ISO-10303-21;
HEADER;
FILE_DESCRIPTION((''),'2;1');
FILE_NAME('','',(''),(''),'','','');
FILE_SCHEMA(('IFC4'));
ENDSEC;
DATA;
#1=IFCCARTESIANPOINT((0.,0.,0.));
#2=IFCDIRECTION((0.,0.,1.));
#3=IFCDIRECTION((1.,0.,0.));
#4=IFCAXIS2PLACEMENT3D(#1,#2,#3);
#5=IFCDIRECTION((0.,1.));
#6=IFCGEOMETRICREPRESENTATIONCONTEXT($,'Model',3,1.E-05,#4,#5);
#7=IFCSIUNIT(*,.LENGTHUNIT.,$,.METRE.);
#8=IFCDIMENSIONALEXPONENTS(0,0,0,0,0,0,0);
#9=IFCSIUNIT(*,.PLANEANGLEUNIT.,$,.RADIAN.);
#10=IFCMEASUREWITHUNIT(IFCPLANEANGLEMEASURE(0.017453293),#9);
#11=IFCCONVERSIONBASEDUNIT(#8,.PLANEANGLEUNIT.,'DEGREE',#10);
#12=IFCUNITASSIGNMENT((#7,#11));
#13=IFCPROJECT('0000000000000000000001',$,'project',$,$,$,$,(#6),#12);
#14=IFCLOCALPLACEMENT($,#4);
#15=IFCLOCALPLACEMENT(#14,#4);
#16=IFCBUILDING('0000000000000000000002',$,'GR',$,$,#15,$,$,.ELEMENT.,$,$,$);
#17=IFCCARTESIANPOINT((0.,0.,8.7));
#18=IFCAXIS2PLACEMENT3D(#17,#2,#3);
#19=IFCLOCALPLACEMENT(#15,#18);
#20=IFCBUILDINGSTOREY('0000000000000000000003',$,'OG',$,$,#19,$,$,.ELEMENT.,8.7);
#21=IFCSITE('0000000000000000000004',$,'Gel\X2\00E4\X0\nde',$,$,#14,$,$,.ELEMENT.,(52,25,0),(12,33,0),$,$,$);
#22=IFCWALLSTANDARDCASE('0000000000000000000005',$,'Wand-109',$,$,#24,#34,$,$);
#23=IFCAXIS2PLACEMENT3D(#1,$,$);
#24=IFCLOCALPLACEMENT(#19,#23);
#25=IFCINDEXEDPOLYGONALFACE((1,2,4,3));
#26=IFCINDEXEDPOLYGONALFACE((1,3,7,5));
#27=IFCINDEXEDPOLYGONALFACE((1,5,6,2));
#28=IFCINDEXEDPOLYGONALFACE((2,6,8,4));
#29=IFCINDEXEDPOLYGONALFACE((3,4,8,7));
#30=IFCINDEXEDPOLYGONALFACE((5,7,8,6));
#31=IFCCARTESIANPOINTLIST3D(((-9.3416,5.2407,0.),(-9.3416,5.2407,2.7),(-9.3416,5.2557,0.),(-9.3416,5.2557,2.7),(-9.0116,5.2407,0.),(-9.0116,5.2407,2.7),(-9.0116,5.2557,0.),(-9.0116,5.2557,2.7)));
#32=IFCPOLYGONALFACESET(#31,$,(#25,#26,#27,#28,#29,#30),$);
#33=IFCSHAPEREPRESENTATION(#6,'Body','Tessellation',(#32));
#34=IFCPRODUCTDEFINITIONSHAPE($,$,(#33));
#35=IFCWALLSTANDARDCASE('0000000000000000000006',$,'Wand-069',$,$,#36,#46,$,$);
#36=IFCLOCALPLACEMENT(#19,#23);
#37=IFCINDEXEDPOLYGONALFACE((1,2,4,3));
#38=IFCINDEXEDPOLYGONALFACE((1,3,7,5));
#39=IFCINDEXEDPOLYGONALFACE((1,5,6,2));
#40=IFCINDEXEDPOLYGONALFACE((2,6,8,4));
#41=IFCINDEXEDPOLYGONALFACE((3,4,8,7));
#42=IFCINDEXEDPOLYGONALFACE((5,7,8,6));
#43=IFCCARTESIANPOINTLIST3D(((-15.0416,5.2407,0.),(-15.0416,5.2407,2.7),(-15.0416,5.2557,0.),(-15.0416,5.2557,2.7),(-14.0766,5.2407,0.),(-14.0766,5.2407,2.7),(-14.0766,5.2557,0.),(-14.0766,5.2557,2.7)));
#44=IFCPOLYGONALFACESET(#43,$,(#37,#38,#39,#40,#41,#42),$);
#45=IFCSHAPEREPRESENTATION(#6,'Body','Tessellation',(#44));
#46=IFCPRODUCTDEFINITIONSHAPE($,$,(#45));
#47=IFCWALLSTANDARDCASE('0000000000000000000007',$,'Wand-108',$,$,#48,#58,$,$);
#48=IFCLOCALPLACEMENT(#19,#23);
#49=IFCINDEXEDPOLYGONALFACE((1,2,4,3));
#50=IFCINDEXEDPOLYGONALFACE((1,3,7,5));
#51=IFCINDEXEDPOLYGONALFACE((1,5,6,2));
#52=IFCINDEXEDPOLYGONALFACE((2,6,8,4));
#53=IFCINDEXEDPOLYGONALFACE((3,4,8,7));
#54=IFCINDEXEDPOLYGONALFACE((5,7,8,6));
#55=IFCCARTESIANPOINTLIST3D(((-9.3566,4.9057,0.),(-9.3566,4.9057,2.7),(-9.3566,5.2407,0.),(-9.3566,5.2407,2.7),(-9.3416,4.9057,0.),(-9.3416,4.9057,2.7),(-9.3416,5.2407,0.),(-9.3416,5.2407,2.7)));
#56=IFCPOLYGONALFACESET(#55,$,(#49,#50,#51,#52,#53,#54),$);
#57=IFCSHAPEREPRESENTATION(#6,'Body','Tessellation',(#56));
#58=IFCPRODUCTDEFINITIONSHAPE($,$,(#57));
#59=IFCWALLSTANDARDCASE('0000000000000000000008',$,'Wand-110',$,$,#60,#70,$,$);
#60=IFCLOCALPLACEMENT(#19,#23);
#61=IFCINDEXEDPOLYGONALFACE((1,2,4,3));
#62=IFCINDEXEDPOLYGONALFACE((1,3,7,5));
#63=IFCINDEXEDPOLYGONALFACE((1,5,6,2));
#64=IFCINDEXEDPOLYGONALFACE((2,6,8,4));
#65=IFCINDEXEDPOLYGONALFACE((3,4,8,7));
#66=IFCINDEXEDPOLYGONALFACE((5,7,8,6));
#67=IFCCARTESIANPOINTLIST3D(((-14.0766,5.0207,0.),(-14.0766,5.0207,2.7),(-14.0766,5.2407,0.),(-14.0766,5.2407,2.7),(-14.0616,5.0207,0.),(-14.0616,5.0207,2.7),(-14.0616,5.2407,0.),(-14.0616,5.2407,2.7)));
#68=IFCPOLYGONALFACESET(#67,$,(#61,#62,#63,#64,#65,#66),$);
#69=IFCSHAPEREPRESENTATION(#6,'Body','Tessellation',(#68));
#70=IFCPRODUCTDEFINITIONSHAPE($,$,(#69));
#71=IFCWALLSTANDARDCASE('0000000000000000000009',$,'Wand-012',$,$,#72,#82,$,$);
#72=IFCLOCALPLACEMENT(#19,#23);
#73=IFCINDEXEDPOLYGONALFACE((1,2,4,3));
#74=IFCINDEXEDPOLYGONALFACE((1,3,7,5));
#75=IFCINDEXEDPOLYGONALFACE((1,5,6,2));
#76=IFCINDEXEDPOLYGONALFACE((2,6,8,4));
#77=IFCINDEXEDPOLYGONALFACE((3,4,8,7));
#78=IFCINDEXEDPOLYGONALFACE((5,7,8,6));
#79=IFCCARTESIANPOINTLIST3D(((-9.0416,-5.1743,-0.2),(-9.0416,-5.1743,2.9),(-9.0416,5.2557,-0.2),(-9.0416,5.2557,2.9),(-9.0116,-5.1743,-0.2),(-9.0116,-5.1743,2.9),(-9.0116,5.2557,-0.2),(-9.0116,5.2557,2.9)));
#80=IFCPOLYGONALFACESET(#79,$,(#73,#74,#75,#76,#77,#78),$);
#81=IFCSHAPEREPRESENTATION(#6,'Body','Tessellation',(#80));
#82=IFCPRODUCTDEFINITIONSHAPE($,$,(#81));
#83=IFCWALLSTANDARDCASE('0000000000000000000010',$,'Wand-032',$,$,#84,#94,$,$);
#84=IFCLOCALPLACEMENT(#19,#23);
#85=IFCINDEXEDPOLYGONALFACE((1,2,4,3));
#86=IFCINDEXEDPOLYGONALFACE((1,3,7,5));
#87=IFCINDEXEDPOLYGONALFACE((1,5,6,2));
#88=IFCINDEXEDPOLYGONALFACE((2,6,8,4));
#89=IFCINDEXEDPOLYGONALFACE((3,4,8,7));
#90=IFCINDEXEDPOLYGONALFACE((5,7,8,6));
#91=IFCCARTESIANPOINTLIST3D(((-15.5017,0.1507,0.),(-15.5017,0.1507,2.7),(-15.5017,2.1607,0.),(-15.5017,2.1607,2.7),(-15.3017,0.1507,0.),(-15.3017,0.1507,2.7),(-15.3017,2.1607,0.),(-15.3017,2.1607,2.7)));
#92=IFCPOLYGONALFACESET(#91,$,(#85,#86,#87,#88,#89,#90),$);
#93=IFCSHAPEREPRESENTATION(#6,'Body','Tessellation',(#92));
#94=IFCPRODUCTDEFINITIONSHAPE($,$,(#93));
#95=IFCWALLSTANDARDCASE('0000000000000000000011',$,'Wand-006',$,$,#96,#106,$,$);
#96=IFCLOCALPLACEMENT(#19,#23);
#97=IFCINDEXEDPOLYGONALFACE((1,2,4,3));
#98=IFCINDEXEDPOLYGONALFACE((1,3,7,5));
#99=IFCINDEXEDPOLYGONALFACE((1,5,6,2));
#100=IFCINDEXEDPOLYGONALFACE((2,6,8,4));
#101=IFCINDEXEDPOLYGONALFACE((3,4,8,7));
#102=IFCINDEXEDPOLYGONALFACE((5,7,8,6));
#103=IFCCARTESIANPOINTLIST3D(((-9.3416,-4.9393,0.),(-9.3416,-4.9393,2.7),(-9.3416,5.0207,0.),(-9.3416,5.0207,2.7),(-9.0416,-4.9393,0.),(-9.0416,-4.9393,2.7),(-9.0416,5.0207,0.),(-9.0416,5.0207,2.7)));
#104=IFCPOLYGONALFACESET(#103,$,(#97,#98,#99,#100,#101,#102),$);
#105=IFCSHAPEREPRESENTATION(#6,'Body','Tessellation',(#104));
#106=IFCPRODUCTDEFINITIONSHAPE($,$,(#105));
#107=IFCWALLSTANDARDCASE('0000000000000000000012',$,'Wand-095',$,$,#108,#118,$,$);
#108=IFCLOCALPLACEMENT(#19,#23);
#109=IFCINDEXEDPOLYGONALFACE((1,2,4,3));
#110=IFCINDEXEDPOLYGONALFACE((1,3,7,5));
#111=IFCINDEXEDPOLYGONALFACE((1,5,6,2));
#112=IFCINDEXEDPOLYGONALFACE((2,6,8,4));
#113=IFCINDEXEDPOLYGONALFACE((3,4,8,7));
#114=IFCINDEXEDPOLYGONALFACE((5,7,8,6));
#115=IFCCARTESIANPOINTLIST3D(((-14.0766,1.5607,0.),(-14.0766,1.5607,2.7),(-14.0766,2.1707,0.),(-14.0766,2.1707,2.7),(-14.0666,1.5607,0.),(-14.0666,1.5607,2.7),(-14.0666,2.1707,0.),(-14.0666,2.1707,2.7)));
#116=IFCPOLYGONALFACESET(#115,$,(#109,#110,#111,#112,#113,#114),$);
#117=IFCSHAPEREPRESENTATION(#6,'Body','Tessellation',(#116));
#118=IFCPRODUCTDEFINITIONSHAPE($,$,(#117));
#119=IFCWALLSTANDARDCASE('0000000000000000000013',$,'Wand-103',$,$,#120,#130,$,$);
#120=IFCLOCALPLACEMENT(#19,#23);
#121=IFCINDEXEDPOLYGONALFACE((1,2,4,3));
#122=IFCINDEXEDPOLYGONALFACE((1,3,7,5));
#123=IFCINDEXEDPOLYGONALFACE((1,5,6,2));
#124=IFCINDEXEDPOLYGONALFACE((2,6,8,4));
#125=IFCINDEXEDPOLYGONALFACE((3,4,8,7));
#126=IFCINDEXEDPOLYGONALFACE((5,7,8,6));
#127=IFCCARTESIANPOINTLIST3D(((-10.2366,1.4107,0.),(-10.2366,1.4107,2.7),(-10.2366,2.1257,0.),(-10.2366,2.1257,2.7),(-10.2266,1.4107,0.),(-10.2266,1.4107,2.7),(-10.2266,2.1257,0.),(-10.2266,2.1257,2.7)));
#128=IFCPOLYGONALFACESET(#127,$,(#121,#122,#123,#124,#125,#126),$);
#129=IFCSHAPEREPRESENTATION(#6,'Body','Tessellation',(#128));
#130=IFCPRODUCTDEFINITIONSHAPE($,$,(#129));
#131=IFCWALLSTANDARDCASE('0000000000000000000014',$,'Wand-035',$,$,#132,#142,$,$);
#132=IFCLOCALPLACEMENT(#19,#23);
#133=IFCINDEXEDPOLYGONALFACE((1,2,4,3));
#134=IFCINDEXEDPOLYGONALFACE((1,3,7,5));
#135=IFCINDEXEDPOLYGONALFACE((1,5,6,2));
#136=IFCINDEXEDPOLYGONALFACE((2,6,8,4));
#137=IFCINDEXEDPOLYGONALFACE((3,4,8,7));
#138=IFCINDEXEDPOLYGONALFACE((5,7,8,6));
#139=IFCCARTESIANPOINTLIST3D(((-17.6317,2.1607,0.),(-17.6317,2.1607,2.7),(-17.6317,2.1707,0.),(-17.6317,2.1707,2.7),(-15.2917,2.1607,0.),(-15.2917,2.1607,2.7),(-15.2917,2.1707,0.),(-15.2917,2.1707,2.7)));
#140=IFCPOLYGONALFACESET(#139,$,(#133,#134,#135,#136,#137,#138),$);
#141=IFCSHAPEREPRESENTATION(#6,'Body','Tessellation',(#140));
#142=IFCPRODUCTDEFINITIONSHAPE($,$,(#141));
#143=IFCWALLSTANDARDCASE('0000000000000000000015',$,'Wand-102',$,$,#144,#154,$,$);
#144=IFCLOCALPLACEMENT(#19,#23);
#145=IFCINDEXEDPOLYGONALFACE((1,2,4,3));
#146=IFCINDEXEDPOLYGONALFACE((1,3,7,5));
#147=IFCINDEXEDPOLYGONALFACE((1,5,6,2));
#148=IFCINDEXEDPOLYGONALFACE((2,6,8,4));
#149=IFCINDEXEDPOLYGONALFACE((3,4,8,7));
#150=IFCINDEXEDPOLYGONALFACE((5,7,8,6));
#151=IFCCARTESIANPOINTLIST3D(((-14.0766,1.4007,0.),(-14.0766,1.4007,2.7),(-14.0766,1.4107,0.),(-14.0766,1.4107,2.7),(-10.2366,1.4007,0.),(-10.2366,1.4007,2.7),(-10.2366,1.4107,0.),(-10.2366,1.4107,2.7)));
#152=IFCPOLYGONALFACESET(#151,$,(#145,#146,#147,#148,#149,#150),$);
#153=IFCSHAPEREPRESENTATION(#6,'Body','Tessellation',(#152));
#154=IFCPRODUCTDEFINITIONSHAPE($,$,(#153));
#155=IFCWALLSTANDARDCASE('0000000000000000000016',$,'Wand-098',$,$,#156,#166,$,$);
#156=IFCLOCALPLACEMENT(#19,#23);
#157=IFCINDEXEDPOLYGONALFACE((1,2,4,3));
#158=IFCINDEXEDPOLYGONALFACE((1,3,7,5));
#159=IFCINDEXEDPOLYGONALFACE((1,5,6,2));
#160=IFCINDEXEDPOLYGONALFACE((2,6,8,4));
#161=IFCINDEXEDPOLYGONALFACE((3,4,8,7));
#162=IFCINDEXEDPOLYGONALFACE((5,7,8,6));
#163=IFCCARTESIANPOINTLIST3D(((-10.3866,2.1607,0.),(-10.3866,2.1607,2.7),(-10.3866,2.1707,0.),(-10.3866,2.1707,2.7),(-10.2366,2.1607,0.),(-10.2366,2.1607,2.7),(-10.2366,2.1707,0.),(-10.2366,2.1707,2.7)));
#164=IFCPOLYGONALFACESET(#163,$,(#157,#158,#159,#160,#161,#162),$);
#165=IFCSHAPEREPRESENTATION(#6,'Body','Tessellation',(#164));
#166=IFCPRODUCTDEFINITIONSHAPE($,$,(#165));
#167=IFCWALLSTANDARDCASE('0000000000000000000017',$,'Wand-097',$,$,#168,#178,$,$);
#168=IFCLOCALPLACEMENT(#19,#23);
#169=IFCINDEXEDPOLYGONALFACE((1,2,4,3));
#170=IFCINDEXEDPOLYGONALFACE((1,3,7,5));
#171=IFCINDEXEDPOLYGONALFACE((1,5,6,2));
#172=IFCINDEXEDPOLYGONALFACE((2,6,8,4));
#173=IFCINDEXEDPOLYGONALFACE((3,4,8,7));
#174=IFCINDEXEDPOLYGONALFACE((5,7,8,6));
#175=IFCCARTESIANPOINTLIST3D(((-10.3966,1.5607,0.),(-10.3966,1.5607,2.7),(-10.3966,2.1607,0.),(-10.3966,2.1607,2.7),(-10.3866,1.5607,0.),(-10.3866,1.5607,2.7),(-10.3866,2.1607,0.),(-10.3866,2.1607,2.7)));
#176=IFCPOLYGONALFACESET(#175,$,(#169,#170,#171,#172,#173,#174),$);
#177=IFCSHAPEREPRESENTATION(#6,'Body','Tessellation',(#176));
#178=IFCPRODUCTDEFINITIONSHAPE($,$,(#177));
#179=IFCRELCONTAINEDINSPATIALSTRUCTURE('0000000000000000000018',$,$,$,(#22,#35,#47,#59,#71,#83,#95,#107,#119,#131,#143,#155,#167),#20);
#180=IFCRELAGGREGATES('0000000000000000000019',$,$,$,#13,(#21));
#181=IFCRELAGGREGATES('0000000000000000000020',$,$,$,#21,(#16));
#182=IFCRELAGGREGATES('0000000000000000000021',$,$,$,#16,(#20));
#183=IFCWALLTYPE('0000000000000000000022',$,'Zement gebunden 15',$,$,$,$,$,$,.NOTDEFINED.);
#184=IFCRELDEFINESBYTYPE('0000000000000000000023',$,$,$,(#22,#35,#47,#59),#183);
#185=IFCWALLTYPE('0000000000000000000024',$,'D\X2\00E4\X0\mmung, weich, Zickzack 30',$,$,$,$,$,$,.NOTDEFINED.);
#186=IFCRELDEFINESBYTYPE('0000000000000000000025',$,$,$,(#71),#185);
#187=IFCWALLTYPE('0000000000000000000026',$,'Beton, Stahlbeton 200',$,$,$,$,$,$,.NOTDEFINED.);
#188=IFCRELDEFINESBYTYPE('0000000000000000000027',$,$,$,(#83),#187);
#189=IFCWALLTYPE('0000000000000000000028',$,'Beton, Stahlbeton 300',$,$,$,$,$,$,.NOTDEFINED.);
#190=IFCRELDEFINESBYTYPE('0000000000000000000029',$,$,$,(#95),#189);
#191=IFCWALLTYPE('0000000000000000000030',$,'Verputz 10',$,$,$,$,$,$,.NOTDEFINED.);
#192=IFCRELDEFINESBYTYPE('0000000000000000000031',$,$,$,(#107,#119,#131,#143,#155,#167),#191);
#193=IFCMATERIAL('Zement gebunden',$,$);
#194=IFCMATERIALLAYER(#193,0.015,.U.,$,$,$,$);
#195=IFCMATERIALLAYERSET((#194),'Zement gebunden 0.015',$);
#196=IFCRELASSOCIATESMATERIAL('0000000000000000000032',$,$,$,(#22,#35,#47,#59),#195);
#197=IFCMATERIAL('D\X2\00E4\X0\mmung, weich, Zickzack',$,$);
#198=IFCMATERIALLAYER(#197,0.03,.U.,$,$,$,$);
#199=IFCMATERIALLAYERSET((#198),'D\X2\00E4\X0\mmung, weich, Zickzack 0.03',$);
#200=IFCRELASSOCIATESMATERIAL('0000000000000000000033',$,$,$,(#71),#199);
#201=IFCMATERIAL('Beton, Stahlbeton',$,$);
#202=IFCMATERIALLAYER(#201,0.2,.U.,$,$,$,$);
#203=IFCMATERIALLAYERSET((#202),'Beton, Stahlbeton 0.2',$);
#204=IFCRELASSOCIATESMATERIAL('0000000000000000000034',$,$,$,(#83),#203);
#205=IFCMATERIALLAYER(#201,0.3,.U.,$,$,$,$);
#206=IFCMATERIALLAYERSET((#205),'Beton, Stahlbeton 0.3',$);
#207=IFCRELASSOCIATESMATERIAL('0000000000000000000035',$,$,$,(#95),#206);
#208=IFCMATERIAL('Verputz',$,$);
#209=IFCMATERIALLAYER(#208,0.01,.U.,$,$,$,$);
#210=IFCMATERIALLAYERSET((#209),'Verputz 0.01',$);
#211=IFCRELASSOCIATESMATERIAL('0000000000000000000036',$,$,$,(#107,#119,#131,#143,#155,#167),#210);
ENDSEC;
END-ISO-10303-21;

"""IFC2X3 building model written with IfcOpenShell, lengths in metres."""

from ifc_helpers import new_model, entity, si_unit, converted_unit, direction, frame, origin_with_axes, place, context, project, spatial, polyline, outline, extrude, material, layer, layer_set, layer_usage, type_object, element, save


model = new_model("IFC2X3")

# Units and contexts
model_context = context("Model", 3, precision=1e-05, world=origin_with_axes(), true_north=direction((0.0, 1.0)))
ifc_project = project(units=[si_unit("LENGTHUNIT", "METRE"), converted_unit("PLANEANGLEUNIT", "DEGREE", entity("IfcPlaneAngleMeasure", 0.017453293), si_unit("PLANEANGLEUNIT", "RADIAN"), dimensions=[0, 0, 0, 0, 0, 0, 0])], contexts=[model_context])

# Site, building, storey
site_placement = place(None, origin_with_axes())
site = spatial("IfcSite", under=ifc_project, at=site_placement, Name="Gelände", CompositionType="ELEMENT", RefLatitude=(52, 25, 0), RefLongitude=(12, 33, 0))
building_placement = place(site_placement, origin_with_axes())
building = spatial("IfcBuilding", under=site, at=building_placement, Name="GR", CompositionType="ELEMENT")
storey_placement = place(building_placement, frame((0.0, 0.0, 8.7), z_axis=(0.0, 0.0, 1.0), x_axis=(1.0, 0.0, 0.0)))
storey = spatial("IfcBuildingStorey", under=building, at=storey_placement, Name="OG", CompositionType="ELEMENT", Elevation=8.7)

# Walls
ifc_material_1 = material(Name="Zement gebunden")
ifc_layer_1 = layer(ifc_material_1, 0.015, ventilated="UNKNOWN")
ifc_layer_set_1 = layer_set([ifc_layer_1], Name="Zement gebunden 0.015")
ifc_layer_usage_1 = layer_usage(ifc_layer_set_1, "AXIS2", "POSITIVE", 0.0)
wall_type_1 = type_object("IfcWallType", Name="Zement gebunden 15", PredefinedType="NOTDEFINED")
wall_1_placement = place(storey_placement, frame((-9.3416, 5.2407, 0.0), z_axis=(0.0, 0.0, 1.0), x_axis=(1.0, 0.0, 0.0)))
element("IfcWallStandardCase", 1, at=wall_1_placement, inside=storey, type_object=wall_type_1, material=ifc_layer_usage_1, Name="Wand-109", context=model_context, shape_type="SweptSolid", body=[
    extrude(outline(polyline([(0.0, 0.0), (0.33, 0.0), (0.33, 0.015), (0.0, 0.015), (0.0, 0.0)])), origin_with_axes(), (0.0, 0.0, 1.0), 2.7),
])
ifc_layer_usage_2 = layer_usage(ifc_layer_set_1, "AXIS2", "NEGATIVE", 0.0)
wall_2_placement = place(storey_placement, frame((-14.0766, 5.2407, 0.0), z_axis=(0.0, 0.0, 1.0), x_axis=(-1.0, 0.0, 0.0)))
element("IfcWallStandardCase", 2, at=wall_2_placement, inside=storey, type_object=wall_type_1, material=ifc_layer_usage_2, Name="Wand-069", context=model_context, shape_type="SweptSolid", body=[
    extrude(outline(polyline([(0.0, -0.015), (0.965, -0.015), (0.965, 0.0), (0.0, 0.0), (0.0, -0.015)])), origin_with_axes(), (0.0, 0.0, 1.0), 2.7),
])
ifc_layer_usage_3 = layer_usage(ifc_layer_set_1, "AXIS2", "POSITIVE", 0.0)
wall_3_placement = place(storey_placement, frame((-9.3416, 4.9057, 0.0), z_axis=(0.0, 0.0, 1.0), x_axis=(0.0, 1.0, 0.0)))
element("IfcWallStandardCase", 3, at=wall_3_placement, inside=storey, type_object=wall_type_1, material=ifc_layer_usage_3, Name="Wand-108", context=model_context, shape_type="SweptSolid", body=[
    extrude(outline(polyline([(0.0, 0.0), (0.335, 0.0), (0.335, 0.015), (0.0, 0.015), (0.0, 0.0)])), origin_with_axes(), (0.0, 0.0, 1.0), 2.7),
])
ifc_layer_usage_4 = layer_usage(ifc_layer_set_1, "AXIS2", "NEGATIVE", 0.0)
wall_4_placement = place(storey_placement, frame((-14.0766, 5.0207, 0.0), z_axis=(0.0, 0.0, 1.0), x_axis=(0.0, 1.0, 0.0)))
element("IfcWallStandardCase", 4, at=wall_4_placement, inside=storey, type_object=wall_type_1, material=ifc_layer_usage_4, Name="Wand-110", context=model_context, shape_type="SweptSolid", body=[
    extrude(outline(polyline([(0.0, -0.015), (0.22, -0.015), (0.22, 0.0), (0.0, 0.0), (0.0, -0.015)])), origin_with_axes(), (0.0, 0.0, 1.0), 2.7),
])
ifc_material_2 = material(Name="Dämmung, weich, Zickzack")
ifc_layer_2 = layer(ifc_material_2, 0.03, ventilated="UNKNOWN")
ifc_layer_set_2 = layer_set([ifc_layer_2], Name="Dämmung, weich, Zickzack 0.03")
ifc_layer_usage_5 = layer_usage(ifc_layer_set_2, "AXIS2", "POSITIVE", 0.0)
wall_type_2 = type_object("IfcWallType", Name="Dämmung, weich, Zickzack 30", PredefinedType="NOTDEFINED")
wall_5_placement = place(storey_placement, frame((-9.0416, 5.2557, -0.2), z_axis=(0.0, 0.0, 1.0), x_axis=(0.0, -1.0, 0.0)))
element("IfcWallStandardCase", 5, at=wall_5_placement, inside=storey, type_object=wall_type_2, material=ifc_layer_usage_5, Name="Wand-012", context=model_context, shape_type="SweptSolid", body=[
    extrude(outline(polyline([(0.0, 0.0), (10.43, 0.0), (10.43, 0.03), (0.0, 0.03), (0.0, 0.0)])), origin_with_axes(), (0.0, 0.0, 1.0), 3.1),
])
ifc_material_3 = material(Name="Beton, Stahlbeton")
ifc_layer_3 = layer(ifc_material_3, 0.2, ventilated="UNKNOWN")
ifc_layer_set_3 = layer_set([ifc_layer_3], Name="Beton, Stahlbeton 0.2")
ifc_layer_usage_6 = layer_usage(ifc_layer_set_3, "AXIS2", "NEGATIVE", 0.0)
wall_type_3 = type_object("IfcWallType", Name="Beton, Stahlbeton 200", PredefinedType="NOTDEFINED")
wall_6_placement = place(storey_placement, frame((-15.3017, 2.1607, 0.0), z_axis=(0.0, 0.0, 1.0), x_axis=(0.0, -1.0, 0.0)))
element("IfcWallStandardCase", 6, at=wall_6_placement, inside=storey, type_object=wall_type_3, material=ifc_layer_usage_6, Name="Wand-032", context=model_context, shape_type="SweptSolid", body=[
    extrude(outline(polyline([(0.0, -0.2), (2.01, -0.2), (2.01, 0.0), (0.0, 0.0), (0.0, -0.2)])), origin_with_axes(), (0.0, 0.0, 1.0), 2.7),
])
ifc_layer_4 = layer(ifc_material_3, 0.3, ventilated="UNKNOWN")
ifc_layer_set_4 = layer_set([ifc_layer_4], Name="Beton, Stahlbeton 0.3")
ifc_layer_usage_7 = layer_usage(ifc_layer_set_4, "AXIS2", "NEGATIVE", 0.0)
wall_type_4 = type_object("IfcWallType", Name="Beton, Stahlbeton 300", PredefinedType="NOTDEFINED")
wall_7_placement = place(storey_placement, frame((-9.0416, 5.0207, 0.0), z_axis=(0.0, 0.0, 1.0), x_axis=(0.0, -1.0, 0.0)))
element("IfcWallStandardCase", 7, at=wall_7_placement, inside=storey, type_object=wall_type_4, material=ifc_layer_usage_7, Name="Wand-006", context=model_context, shape_type="SweptSolid", body=[
    extrude(outline(polyline([(0.0, -0.3), (9.96, -0.3), (9.96, 0.0), (0.0, 0.0), (0.0, -0.3)])), origin_with_axes(), (0.0, 0.0, 1.0), 2.7),
])
ifc_material_4 = material(Name="Verputz")
ifc_layer_5 = layer(ifc_material_4, 0.01, ventilated="UNKNOWN")
ifc_layer_set_5 = layer_set([ifc_layer_5], Name="Verputz 0.01")
ifc_layer_usage_8 = layer_usage(ifc_layer_set_5, "AXIS2", "POSITIVE", 0.0)
wall_type_5 = type_object("IfcWallType", Name="Verputz 10", PredefinedType="NOTDEFINED")
wall_8_placement = place(storey_placement, frame((-14.0766, 2.1707, 0.0), z_axis=(0.0, 0.0, 1.0), x_axis=(0.0, -1.0, 0.0)))
element("IfcWallStandardCase", 8, at=wall_8_placement, inside=storey, type_object=wall_type_5, material=ifc_layer_usage_8, Name="Wand-095", context=model_context, shape_type="SweptSolid", body=[
    extrude(outline(polyline([(0.0, 0.0), (0.61, 0.0), (0.61, 0.01), (0.0, 0.01), (0.0, 0.0)])), origin_with_axes(), (0.0, 0.0, 1.0), 2.7),
])
ifc_layer_usage_9 = layer_usage(ifc_layer_set_5, "AXIS2", "NEGATIVE", 0.0)
wall_9_placement = place(storey_placement, frame((-10.2366, 1.4107, 0.0), z_axis=(0.0, 0.0, 1.0), x_axis=(0.0, 1.0, 0.0)))
element("IfcWallStandardCase", 9, at=wall_9_placement, inside=storey, type_object=wall_type_5, material=ifc_layer_usage_9, Name="Wand-103", context=model_context, shape_type="SweptSolid", body=[
    extrude(outline(polyline([(0.0, -0.01), (0.715, -0.01), (0.715, 0.0), (0.0, 0.0), (0.0, -0.01)])), origin_with_axes(), (0.0, 0.0, 1.0), 2.7),
])
ifc_layer_usage_10 = layer_usage(ifc_layer_set_5, "AXIS2", "NEGATIVE", 0.0)
wall_10_placement = place(storey_placement, frame((-15.2917, 2.1607, 0.0), z_axis=(0.0, 0.0, 1.0), x_axis=(-1.0, 0.0, 0.0)))
element("IfcWallStandardCase", 10, at=wall_10_placement, inside=storey, type_object=wall_type_5, material=ifc_layer_usage_10, Name="Wand-035", context=model_context, shape_type="SweptSolid", body=[
    extrude(outline(polyline([(0.0, -0.01), (2.34, -0.01), (2.34, 0.0), (0.0, 0.0), (0.0, -0.01)])), origin_with_axes(), (0.0, 0.0, 1.0), 2.7),
])
ifc_layer_usage_11 = layer_usage(ifc_layer_set_5, "AXIS2", "NEGATIVE", 0.0)
wall_11_placement = place(storey_placement, frame((-14.0766, 1.4107, 0.0), z_axis=(0.0, 0.0, 1.0), x_axis=(1.0, 0.0, 0.0)))
element("IfcWallStandardCase", 11, at=wall_11_placement, inside=storey, type_object=wall_type_5, material=ifc_layer_usage_11, Name="Wand-102", context=model_context, shape_type="SweptSolid", body=[
    extrude(outline(polyline([(0.0, -0.01), (3.84, -0.01), (3.84, 0.0), (0.0, 0.0), (0.0, -0.01)])), origin_with_axes(), (0.0, 0.0, 1.0), 2.7),
])
ifc_layer_usage_12 = layer_usage(ifc_layer_set_5, "AXIS2", "POSITIVE", 0.0)
wall_12_placement = place(storey_placement, frame((-10.3866, 2.1607, 0.0), z_axis=(0.0, 0.0, 1.0), x_axis=(1.0, 0.0, 0.0)))
element("IfcWallStandardCase", 12, at=wall_12_placement, inside=storey, type_object=wall_type_5, material=ifc_layer_usage_12, Name="Wand-098", context=model_context, shape_type="SweptSolid", body=[
    extrude(outline(polyline([(0.0, 0.0), (0.15, 0.0), (0.15, 0.01), (0.0, 0.01), (0.0, 0.0)])), origin_with_axes(), (0.0, 0.0, 1.0), 2.7),
])
ifc_layer_usage_13 = layer_usage(ifc_layer_set_5, "AXIS2", "POSITIVE", 0.0)
wall_13_placement = place(storey_placement, frame((-10.3866, 1.5607, 0.0), z_axis=(0.0, 0.0, 1.0), x_axis=(0.0, 1.0, 0.0)))
element("IfcWallStandardCase", 13, at=wall_13_placement, inside=storey, type_object=wall_type_5, material=ifc_layer_usage_13, Name="Wand-097", context=model_context, shape_type="SweptSolid", body=[
    extrude(outline(polyline([(0.0, 0.0), (0.6, 0.0), (0.6, 0.01), (0.0, 0.01), (0.0, 0.0)])), origin_with_axes(), (0.0, 0.0, 1.0), 2.7),
])

save(model, "model.ifc")
